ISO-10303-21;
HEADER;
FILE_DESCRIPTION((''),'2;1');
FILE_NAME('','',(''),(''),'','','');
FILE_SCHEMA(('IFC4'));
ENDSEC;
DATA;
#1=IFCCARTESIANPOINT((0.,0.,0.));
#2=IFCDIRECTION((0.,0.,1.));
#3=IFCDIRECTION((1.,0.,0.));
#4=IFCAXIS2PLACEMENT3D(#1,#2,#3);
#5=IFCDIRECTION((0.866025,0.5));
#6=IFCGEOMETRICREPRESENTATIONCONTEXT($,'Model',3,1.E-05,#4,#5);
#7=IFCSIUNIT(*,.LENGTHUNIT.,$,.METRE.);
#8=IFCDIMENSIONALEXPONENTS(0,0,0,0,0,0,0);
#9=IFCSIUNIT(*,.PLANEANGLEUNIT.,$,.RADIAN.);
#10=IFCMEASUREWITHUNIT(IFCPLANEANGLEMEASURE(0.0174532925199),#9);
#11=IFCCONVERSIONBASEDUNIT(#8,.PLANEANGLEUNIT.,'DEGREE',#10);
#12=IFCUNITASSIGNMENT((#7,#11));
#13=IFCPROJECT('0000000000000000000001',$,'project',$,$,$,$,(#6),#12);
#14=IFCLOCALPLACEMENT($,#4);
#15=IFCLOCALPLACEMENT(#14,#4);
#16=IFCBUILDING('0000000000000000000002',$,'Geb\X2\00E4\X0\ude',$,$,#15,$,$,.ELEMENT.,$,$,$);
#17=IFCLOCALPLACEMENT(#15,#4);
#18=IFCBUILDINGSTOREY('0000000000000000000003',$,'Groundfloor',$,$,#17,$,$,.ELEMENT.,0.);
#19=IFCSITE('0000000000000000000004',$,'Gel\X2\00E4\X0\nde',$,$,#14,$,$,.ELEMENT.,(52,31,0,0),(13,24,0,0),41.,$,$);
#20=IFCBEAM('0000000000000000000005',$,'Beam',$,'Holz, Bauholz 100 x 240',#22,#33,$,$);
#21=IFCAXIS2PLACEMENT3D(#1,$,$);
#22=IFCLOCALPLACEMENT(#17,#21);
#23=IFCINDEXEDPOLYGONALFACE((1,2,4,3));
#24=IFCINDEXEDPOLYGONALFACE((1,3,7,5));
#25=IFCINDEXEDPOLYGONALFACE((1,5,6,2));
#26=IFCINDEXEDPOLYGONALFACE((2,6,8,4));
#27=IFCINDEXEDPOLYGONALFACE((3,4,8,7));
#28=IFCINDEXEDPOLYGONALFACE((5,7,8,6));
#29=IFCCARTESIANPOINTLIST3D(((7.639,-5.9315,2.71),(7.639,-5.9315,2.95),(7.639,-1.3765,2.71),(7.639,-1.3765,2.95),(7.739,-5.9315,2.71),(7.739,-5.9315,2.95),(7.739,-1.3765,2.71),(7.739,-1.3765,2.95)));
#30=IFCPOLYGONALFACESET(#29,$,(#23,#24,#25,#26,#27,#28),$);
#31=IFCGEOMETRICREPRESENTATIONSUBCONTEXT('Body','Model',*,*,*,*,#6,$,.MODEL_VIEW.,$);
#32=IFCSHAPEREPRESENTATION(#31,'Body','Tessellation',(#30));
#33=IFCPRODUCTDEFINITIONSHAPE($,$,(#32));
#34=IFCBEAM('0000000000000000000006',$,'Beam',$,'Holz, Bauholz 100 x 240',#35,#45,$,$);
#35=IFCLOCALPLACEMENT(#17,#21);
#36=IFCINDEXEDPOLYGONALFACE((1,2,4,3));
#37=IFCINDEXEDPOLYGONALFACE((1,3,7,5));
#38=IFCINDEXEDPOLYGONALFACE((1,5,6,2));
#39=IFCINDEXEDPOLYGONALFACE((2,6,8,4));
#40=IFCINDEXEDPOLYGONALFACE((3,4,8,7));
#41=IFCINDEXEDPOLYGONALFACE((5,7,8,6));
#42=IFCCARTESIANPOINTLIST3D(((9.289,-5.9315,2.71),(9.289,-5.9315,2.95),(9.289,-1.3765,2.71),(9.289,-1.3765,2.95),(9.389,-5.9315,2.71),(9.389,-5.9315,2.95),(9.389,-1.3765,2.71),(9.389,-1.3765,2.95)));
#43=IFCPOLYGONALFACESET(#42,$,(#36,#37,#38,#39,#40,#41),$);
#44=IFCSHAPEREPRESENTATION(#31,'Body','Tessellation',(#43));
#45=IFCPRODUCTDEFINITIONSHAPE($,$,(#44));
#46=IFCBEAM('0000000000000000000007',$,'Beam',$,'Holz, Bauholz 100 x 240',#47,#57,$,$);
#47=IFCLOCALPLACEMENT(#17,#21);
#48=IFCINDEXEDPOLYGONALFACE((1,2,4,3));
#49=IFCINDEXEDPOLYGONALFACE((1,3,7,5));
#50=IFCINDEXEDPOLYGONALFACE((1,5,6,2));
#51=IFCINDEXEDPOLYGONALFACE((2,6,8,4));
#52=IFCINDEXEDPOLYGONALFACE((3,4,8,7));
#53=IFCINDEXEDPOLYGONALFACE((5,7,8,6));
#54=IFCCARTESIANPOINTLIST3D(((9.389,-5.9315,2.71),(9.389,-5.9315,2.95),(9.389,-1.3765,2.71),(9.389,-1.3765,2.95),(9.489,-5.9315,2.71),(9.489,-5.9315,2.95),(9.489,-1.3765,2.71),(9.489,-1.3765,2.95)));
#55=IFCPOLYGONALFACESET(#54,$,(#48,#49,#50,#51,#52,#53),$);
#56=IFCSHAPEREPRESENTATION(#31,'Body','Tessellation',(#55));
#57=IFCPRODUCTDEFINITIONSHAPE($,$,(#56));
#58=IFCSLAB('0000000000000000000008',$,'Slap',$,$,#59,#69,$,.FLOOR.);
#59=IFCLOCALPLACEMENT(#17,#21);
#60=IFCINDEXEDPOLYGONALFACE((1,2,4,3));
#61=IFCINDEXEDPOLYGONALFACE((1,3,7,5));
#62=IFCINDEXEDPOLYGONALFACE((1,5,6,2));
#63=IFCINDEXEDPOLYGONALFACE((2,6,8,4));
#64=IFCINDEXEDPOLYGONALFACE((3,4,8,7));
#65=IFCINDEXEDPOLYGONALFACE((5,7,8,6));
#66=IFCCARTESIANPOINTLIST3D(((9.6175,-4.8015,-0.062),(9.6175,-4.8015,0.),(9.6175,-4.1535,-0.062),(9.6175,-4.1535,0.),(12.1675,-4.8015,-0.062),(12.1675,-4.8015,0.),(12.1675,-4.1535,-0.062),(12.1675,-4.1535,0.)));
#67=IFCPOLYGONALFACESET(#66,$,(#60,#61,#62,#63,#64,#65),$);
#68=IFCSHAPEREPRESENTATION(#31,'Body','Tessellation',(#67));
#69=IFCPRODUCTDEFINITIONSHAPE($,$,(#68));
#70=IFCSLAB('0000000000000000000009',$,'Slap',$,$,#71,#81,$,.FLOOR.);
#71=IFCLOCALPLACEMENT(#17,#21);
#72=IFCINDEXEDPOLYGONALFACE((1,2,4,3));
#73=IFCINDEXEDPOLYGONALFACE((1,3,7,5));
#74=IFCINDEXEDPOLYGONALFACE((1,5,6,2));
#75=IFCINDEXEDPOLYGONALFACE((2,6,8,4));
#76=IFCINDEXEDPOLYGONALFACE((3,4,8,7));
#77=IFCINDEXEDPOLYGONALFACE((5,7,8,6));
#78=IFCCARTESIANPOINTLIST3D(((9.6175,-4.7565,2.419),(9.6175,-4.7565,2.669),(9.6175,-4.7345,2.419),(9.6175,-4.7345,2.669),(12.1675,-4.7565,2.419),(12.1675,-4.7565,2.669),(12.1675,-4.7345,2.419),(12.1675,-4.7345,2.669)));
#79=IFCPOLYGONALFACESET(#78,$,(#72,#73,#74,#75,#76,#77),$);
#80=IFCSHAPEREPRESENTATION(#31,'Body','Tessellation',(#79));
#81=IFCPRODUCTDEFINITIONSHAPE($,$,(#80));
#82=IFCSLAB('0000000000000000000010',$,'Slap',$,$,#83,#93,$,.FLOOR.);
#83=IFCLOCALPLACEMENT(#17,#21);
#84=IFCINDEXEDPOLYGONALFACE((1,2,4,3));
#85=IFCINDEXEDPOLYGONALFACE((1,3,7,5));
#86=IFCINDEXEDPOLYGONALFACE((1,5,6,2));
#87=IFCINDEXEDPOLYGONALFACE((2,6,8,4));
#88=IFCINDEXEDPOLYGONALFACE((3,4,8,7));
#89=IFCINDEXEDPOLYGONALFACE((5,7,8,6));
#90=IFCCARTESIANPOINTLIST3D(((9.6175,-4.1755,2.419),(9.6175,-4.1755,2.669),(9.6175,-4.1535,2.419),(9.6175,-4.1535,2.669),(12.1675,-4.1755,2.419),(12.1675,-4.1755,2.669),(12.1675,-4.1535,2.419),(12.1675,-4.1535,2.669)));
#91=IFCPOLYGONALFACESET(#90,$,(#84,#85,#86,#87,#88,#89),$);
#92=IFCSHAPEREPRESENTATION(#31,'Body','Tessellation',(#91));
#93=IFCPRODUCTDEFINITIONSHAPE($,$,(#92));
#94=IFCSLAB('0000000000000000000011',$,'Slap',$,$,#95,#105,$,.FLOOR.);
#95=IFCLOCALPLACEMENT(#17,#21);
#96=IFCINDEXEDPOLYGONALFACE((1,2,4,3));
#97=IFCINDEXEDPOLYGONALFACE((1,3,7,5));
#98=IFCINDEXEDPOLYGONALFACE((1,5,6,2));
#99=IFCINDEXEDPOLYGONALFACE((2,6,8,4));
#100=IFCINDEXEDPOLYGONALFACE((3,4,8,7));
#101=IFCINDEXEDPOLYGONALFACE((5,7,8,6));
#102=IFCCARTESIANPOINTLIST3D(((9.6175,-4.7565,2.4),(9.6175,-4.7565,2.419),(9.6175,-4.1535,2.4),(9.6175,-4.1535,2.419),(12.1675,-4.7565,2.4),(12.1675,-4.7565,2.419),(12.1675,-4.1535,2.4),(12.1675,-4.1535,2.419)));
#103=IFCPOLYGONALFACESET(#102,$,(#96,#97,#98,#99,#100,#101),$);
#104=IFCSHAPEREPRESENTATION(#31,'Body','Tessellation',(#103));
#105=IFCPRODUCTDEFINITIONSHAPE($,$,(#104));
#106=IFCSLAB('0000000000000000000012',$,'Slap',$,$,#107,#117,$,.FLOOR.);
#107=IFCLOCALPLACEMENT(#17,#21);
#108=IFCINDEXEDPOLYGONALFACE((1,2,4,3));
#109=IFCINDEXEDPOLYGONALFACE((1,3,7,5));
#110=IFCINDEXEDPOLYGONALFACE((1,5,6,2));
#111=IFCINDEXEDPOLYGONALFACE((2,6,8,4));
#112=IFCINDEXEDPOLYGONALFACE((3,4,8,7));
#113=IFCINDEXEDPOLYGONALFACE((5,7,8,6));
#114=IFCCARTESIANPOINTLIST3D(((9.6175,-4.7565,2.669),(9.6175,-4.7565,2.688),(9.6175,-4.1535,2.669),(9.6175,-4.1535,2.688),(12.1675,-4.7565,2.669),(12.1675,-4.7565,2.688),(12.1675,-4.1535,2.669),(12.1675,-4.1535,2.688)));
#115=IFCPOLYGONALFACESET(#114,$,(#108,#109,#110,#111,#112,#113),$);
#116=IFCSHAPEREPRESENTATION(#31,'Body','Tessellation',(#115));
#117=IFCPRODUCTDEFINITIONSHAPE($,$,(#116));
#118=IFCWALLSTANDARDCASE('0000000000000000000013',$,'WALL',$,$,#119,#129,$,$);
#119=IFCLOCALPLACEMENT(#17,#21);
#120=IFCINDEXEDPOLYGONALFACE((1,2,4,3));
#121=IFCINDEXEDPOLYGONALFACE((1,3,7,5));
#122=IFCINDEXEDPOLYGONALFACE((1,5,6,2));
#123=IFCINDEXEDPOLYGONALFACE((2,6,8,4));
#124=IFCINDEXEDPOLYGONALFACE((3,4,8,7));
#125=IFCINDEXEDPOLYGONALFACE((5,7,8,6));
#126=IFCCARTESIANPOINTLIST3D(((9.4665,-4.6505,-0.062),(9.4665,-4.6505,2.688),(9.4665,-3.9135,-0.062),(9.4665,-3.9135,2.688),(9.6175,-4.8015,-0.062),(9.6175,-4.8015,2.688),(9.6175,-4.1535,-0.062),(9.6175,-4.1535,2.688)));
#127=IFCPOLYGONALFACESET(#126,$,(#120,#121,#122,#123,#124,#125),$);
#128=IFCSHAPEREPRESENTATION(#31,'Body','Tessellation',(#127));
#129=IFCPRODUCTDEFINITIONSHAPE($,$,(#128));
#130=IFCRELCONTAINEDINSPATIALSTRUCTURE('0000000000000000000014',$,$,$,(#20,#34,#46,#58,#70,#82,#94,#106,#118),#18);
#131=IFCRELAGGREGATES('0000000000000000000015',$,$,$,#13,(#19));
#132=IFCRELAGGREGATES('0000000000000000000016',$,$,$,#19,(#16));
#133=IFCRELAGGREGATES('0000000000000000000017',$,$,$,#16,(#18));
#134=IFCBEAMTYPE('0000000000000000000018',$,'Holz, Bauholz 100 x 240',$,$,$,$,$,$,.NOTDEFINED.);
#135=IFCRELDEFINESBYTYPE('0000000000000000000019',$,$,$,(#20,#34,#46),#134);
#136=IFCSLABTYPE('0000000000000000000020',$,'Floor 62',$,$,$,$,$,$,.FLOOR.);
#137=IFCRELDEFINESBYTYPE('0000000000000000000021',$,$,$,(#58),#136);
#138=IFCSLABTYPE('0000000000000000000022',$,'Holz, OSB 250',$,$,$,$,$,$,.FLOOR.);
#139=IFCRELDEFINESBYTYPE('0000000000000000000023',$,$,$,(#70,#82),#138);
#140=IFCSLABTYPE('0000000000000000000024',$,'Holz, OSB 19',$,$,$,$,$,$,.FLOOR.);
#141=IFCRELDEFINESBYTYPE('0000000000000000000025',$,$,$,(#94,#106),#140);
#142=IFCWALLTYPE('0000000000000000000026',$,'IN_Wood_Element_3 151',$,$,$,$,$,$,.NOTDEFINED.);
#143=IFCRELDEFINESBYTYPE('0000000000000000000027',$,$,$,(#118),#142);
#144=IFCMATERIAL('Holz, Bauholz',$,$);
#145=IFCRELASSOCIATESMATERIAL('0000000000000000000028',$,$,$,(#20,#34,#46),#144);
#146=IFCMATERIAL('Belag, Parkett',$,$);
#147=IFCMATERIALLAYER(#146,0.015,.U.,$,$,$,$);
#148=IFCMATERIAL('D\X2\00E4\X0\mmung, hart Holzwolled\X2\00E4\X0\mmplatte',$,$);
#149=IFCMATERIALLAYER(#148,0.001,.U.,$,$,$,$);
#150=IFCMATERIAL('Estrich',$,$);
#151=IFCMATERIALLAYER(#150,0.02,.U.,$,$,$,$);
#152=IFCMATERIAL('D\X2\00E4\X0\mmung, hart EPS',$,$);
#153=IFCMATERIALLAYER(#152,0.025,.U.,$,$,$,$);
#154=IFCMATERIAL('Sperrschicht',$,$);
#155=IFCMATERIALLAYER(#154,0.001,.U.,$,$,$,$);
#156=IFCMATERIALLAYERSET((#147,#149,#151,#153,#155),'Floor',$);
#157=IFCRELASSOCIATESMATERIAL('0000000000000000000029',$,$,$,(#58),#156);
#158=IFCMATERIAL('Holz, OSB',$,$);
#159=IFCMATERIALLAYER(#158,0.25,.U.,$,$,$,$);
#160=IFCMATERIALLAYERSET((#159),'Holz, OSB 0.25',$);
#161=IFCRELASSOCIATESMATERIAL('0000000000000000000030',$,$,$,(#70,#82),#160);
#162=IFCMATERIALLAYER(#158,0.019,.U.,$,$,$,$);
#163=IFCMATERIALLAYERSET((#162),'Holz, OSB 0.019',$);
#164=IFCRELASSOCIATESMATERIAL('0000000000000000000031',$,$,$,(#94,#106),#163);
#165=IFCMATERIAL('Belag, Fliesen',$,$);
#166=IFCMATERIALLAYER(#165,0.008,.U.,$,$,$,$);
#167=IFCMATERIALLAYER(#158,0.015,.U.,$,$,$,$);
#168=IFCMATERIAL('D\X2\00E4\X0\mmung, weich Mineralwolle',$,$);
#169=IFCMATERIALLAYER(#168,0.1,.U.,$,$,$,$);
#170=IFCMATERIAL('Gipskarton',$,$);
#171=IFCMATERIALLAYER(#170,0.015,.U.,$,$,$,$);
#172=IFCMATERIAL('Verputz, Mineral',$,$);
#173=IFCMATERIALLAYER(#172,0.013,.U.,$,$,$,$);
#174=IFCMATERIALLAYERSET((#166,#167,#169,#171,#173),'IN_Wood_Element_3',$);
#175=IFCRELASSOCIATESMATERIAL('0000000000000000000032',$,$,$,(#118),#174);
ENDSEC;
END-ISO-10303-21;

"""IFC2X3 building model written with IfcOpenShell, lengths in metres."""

from ifc_helpers import new_model, entity, si_unit, converted_unit, direction, frame, frame_2d, origin_with_axes, place, context, subcontext, project, spatial, polyline, rectangle, outline, extrude, material, layer, layer_set, layer_usage, type_object, element, save


model = new_model("IFC2X3")

# Units and contexts
model_context = context("Model", 3, precision=1e-05, world=origin_with_axes(), true_north=direction((0.866025, 0.5)))
body_context = subcontext(model_context, "Body", "Model", "MODEL_VIEW")
ifc_project = project(units=[si_unit("LENGTHUNIT", "METRE"), converted_unit("PLANEANGLEUNIT", "DEGREE", entity("IfcPlaneAngleMeasure", 0.0174532925199), si_unit("PLANEANGLEUNIT", "RADIAN"), dimensions=[0, 0, 0, 0, 0, 0, 0])], contexts=[model_context])

# Site, building, storey
site_placement = place(None, origin_with_axes())
site = spatial("IfcSite", under=ifc_project, at=site_placement, Name="Gelände", CompositionType="ELEMENT", RefLatitude=(52, 31, 0, 0), RefLongitude=(13, 24, 0, 0), RefElevation=41.0)
building_placement = place(site_placement, origin_with_axes())
building = spatial("IfcBuilding", under=site, at=building_placement, Name="Gebäude", CompositionType="ELEMENT")
storey_placement = place(building_placement, origin_with_axes())
storey = spatial("IfcBuildingStorey", under=building, at=storey_placement, Name="Groundfloor", CompositionType="ELEMENT", Elevation=0.0)

# Shared definitions
ifc_material_1 = material(Name="Holz, Bauholz")

# Beams
beam_type_1 = type_object("IfcBeamType", Name="Holz, Bauholz 100 x 240", PredefinedType="NOTDEFINED")
for number, where, z_axis, x_axis, name in (
    (1, (7.689, -5.9315, 2.95), (0.0, 0.0, 1.0), (1.0, 0.0, 0.0), "Beam"),
    (2, (9.339, -5.9315, 2.95), (0.0, 0.0, 1.0), (1.0, 0.0, 0.0), "Beam"),
    (3, (9.439, -5.9315, 2.95), (0.0, 0.0, 1.0), (1.0, 0.0, 0.0), "Beam"),
):
    element("IfcBeam", number, at=place(storey_placement, frame(where, z_axis=z_axis, x_axis=x_axis)), inside=storey, type_object=beam_type_1, material=ifc_material_1, Name=name, ObjectType="Holz, Bauholz 100 x 240", context=body_context, shape_type="SweptSolid", body=[
        extrude(rectangle(XDim=0.24, YDim=0.1, at=frame_2d((-0.12, 0.0), x_axis=(1.0, 0.0))), frame((0.0, 0.0, 0.0), z_axis=(0.0, 1.0, 0.0), x_axis=(0.0, 0.0, 1.0)), (0.0, 0.0, 1.0), 4.555),
    ])

# Slabs
ifc_material_2 = material(Name="Belag, Parkett")
ifc_layer_1 = layer(ifc_material_2, 0.015, ventilated="UNKNOWN")
ifc_material_3 = material(Name="Dämmung, hart Holzwolledämmplatte")
ifc_layer_2 = layer(ifc_material_3, 0.001, ventilated="UNKNOWN")
ifc_material_4 = material(Name="Estrich")
ifc_layer_3 = layer(ifc_material_4, 0.02, ventilated="UNKNOWN")
ifc_material_5 = material(Name="Dämmung, hart EPS")
ifc_layer_4 = layer(ifc_material_5, 0.025, ventilated="UNKNOWN")
ifc_material_6 = material(Name="Sperrschicht")
ifc_layer_5 = layer(ifc_material_6, 0.001, ventilated="UNKNOWN")
ifc_layer_set_1 = layer_set([ifc_layer_1, ifc_layer_2, ifc_layer_3, ifc_layer_4, ifc_layer_5], Name="Floor")
ifc_layer_usage_1 = layer_usage(ifc_layer_set_1, "AXIS3", "NEGATIVE", 0.062)
slab_type_1 = type_object("IfcSlabType", Name="Floor 62", PredefinedType="FLOOR")
slab_1_placement = place(storey_placement, frame((9.6175, -4.1535, 0.0), z_axis=(0.0, 0.0, 1.0), x_axis=(1.0, 0.0, 0.0)))
element("IfcSlab", 4, at=slab_1_placement, inside=storey, type_object=slab_type_1, material=ifc_layer_usage_1, Name="Slap", PredefinedType="FLOOR", context=body_context, shape_type="SweptSolid", body=[
    extrude(outline(polyline([(0.0, 0.0), (0.0, -0.648), (2.55, -0.648), (2.55, 0.0), (0.0, 0.0)])), frame((0.0, 0.0, -0.062), z_axis=(0.0, 0.0, 1.0), x_axis=(1.0, 0.0, 0.0)), (0.0, 0.0, 1.0), 0.062),
])
ifc_material_7 = material(Name="Holz, OSB")
ifc_layer_6 = layer(ifc_material_7, 0.25, ventilated="UNKNOWN")
ifc_layer_set_2 = layer_set([ifc_layer_6], Name="Holz, OSB 0.25")
ifc_layer_usage_2 = layer_usage(ifc_layer_set_2, "AXIS3", "NEGATIVE", 0.25)
slab_type_2 = type_object("IfcSlabType", Name="Holz, OSB 250", PredefinedType="FLOOR")
slab_2_placement = place(storey_placement, frame((9.6175, -4.7345, 2.669), z_axis=(0.0, 0.0, 1.0), x_axis=(1.0, 0.0, 0.0)))
element("IfcSlab", 5, at=slab_2_placement, inside=storey, type_object=slab_type_2, material=ifc_layer_usage_2, Name="Slap", PredefinedType="FLOOR", context=body_context, shape_type="SweptSolid", body=[
    extrude(outline(polyline([(0.0, 0.0), (0.0, -0.022), (2.55, -0.022), (2.55, 0.0), (0.0, 0.0)])), frame((0.0, 0.0, -0.25), z_axis=(0.0, 0.0, 1.0), x_axis=(1.0, 0.0, 0.0)), (0.0, 0.0, 1.0), 0.25),
])
ifc_layer_usage_3 = layer_usage(ifc_layer_set_2, "AXIS3", "NEGATIVE", 0.25)
slab_3_placement = place(storey_placement, frame((9.6175, -4.1535, 2.669), z_axis=(0.0, 0.0, 1.0), x_axis=(1.0, 0.0, 0.0)))
element("IfcSlab", 6, at=slab_3_placement, inside=storey, type_object=slab_type_2, material=ifc_layer_usage_3, Name="Slap", PredefinedType="FLOOR", context=body_context, shape_type="SweptSolid", body=[
    extrude(outline(polyline([(0.0, 0.0), (0.0, -0.022), (2.55, -0.022), (2.55, 0.0), (0.0, 0.0)])), frame((0.0, 0.0, -0.25), z_axis=(0.0, 0.0, 1.0), x_axis=(1.0, 0.0, 0.0)), (0.0, 0.0, 1.0), 0.25),
])
ifc_layer_7 = layer(ifc_material_7, 0.019, ventilated="UNKNOWN")
ifc_layer_set_3 = layer_set([ifc_layer_7], Name="Holz, OSB 0.019")
ifc_layer_usage_4 = layer_usage(ifc_layer_set_3, "AXIS3", "NEGATIVE", 0.019)
slab_type_3 = type_object("IfcSlabType", Name="Holz, OSB 19", PredefinedType="FLOOR")
slab_4_placement = place(storey_placement, frame((9.6175, -4.1535, 2.419), z_axis=(0.0, 0.0, 1.0), x_axis=(1.0, 0.0, 0.0)))
element("IfcSlab", 7, at=slab_4_placement, inside=storey, type_object=slab_type_3, material=ifc_layer_usage_4, Name="Slap", PredefinedType="FLOOR", context=body_context, shape_type="SweptSolid", body=[
    extrude(outline(polyline([(0.0, 0.0), (0.0, -0.603), (2.55, -0.603), (2.55, 0.0), (0.0, 0.0)])), frame((0.0, 0.0, -0.019), z_axis=(0.0, 0.0, 1.0), x_axis=(1.0, 0.0, 0.0)), (0.0, 0.0, 1.0), 0.019),
])
ifc_layer_usage_5 = layer_usage(ifc_layer_set_3, "AXIS3", "NEGATIVE", 0.019)
slab_5_placement = place(storey_placement, frame((9.6175, -4.1535, 2.688), z_axis=(0.0, 0.0, 1.0), x_axis=(1.0, 0.0, 0.0)))
element("IfcSlab", 8, at=slab_5_placement, inside=storey, type_object=slab_type_3, material=ifc_layer_usage_5, Name="Slap", PredefinedType="FLOOR", context=body_context, shape_type="SweptSolid", body=[
    extrude(outline(polyline([(0.0, 0.0), (0.0, -0.603), (2.55, -0.603), (2.55, 0.0), (0.0, 0.0)])), frame((0.0, 0.0, -0.019), z_axis=(0.0, 0.0, 1.0), x_axis=(1.0, 0.0, 0.0)), (0.0, 0.0, 1.0), 0.019),
])

# Wall
ifc_material_8 = material(Name="Belag, Fliesen")
ifc_layer_8 = layer(ifc_material_8, 0.008, ventilated="UNKNOWN")
ifc_layer_9 = layer(ifc_material_7, 0.015, ventilated="UNKNOWN")
ifc_material_9 = material(Name="Dämmung, weich Mineralwolle")
ifc_layer_10 = layer(ifc_material_9, 0.1, ventilated="UNKNOWN")
ifc_material_10 = material(Name="Gipskarton")
ifc_layer_11 = layer(ifc_material_10, 0.015, ventilated="UNKNOWN")
ifc_material_11 = material(Name="Verputz, Mineral")
ifc_layer_12 = layer(ifc_material_11, 0.013, ventilated="UNKNOWN")
ifc_layer_set_4 = layer_set([ifc_layer_8, ifc_layer_9, ifc_layer_10, ifc_layer_11, ifc_layer_12], Name="IN_Wood_Element_3")
ifc_layer_usage_6 = layer_usage(ifc_layer_set_4, "AXIS2", "NEGATIVE", 0.151)
wall_type = type_object("IfcWallType", Name="IN_Wood_Element_3 151", PredefinedType="NOTDEFINED")
wall_placement = place(storey_placement, frame((9.6175, -4.8015, -0.062), z_axis=(0.0, 0.0, 1.0), x_axis=(0.0, 1.0, 0.0)))
element("IfcWallStandardCase", 9, at=wall_placement, inside=storey, type_object=wall_type, material=ifc_layer_usage_6, Name="WALL", context=body_context, shape_type="SweptSolid", body=[
    extrude(outline(polyline([(0.0, 0.0), (0.648, 0.0), (0.888, 0.151), (0.151, 0.151), (0.0, 0.0)])), origin_with_axes(), (0.0, 0.0, 1.0), 2.75),
])

save(model, "model.ifc")
